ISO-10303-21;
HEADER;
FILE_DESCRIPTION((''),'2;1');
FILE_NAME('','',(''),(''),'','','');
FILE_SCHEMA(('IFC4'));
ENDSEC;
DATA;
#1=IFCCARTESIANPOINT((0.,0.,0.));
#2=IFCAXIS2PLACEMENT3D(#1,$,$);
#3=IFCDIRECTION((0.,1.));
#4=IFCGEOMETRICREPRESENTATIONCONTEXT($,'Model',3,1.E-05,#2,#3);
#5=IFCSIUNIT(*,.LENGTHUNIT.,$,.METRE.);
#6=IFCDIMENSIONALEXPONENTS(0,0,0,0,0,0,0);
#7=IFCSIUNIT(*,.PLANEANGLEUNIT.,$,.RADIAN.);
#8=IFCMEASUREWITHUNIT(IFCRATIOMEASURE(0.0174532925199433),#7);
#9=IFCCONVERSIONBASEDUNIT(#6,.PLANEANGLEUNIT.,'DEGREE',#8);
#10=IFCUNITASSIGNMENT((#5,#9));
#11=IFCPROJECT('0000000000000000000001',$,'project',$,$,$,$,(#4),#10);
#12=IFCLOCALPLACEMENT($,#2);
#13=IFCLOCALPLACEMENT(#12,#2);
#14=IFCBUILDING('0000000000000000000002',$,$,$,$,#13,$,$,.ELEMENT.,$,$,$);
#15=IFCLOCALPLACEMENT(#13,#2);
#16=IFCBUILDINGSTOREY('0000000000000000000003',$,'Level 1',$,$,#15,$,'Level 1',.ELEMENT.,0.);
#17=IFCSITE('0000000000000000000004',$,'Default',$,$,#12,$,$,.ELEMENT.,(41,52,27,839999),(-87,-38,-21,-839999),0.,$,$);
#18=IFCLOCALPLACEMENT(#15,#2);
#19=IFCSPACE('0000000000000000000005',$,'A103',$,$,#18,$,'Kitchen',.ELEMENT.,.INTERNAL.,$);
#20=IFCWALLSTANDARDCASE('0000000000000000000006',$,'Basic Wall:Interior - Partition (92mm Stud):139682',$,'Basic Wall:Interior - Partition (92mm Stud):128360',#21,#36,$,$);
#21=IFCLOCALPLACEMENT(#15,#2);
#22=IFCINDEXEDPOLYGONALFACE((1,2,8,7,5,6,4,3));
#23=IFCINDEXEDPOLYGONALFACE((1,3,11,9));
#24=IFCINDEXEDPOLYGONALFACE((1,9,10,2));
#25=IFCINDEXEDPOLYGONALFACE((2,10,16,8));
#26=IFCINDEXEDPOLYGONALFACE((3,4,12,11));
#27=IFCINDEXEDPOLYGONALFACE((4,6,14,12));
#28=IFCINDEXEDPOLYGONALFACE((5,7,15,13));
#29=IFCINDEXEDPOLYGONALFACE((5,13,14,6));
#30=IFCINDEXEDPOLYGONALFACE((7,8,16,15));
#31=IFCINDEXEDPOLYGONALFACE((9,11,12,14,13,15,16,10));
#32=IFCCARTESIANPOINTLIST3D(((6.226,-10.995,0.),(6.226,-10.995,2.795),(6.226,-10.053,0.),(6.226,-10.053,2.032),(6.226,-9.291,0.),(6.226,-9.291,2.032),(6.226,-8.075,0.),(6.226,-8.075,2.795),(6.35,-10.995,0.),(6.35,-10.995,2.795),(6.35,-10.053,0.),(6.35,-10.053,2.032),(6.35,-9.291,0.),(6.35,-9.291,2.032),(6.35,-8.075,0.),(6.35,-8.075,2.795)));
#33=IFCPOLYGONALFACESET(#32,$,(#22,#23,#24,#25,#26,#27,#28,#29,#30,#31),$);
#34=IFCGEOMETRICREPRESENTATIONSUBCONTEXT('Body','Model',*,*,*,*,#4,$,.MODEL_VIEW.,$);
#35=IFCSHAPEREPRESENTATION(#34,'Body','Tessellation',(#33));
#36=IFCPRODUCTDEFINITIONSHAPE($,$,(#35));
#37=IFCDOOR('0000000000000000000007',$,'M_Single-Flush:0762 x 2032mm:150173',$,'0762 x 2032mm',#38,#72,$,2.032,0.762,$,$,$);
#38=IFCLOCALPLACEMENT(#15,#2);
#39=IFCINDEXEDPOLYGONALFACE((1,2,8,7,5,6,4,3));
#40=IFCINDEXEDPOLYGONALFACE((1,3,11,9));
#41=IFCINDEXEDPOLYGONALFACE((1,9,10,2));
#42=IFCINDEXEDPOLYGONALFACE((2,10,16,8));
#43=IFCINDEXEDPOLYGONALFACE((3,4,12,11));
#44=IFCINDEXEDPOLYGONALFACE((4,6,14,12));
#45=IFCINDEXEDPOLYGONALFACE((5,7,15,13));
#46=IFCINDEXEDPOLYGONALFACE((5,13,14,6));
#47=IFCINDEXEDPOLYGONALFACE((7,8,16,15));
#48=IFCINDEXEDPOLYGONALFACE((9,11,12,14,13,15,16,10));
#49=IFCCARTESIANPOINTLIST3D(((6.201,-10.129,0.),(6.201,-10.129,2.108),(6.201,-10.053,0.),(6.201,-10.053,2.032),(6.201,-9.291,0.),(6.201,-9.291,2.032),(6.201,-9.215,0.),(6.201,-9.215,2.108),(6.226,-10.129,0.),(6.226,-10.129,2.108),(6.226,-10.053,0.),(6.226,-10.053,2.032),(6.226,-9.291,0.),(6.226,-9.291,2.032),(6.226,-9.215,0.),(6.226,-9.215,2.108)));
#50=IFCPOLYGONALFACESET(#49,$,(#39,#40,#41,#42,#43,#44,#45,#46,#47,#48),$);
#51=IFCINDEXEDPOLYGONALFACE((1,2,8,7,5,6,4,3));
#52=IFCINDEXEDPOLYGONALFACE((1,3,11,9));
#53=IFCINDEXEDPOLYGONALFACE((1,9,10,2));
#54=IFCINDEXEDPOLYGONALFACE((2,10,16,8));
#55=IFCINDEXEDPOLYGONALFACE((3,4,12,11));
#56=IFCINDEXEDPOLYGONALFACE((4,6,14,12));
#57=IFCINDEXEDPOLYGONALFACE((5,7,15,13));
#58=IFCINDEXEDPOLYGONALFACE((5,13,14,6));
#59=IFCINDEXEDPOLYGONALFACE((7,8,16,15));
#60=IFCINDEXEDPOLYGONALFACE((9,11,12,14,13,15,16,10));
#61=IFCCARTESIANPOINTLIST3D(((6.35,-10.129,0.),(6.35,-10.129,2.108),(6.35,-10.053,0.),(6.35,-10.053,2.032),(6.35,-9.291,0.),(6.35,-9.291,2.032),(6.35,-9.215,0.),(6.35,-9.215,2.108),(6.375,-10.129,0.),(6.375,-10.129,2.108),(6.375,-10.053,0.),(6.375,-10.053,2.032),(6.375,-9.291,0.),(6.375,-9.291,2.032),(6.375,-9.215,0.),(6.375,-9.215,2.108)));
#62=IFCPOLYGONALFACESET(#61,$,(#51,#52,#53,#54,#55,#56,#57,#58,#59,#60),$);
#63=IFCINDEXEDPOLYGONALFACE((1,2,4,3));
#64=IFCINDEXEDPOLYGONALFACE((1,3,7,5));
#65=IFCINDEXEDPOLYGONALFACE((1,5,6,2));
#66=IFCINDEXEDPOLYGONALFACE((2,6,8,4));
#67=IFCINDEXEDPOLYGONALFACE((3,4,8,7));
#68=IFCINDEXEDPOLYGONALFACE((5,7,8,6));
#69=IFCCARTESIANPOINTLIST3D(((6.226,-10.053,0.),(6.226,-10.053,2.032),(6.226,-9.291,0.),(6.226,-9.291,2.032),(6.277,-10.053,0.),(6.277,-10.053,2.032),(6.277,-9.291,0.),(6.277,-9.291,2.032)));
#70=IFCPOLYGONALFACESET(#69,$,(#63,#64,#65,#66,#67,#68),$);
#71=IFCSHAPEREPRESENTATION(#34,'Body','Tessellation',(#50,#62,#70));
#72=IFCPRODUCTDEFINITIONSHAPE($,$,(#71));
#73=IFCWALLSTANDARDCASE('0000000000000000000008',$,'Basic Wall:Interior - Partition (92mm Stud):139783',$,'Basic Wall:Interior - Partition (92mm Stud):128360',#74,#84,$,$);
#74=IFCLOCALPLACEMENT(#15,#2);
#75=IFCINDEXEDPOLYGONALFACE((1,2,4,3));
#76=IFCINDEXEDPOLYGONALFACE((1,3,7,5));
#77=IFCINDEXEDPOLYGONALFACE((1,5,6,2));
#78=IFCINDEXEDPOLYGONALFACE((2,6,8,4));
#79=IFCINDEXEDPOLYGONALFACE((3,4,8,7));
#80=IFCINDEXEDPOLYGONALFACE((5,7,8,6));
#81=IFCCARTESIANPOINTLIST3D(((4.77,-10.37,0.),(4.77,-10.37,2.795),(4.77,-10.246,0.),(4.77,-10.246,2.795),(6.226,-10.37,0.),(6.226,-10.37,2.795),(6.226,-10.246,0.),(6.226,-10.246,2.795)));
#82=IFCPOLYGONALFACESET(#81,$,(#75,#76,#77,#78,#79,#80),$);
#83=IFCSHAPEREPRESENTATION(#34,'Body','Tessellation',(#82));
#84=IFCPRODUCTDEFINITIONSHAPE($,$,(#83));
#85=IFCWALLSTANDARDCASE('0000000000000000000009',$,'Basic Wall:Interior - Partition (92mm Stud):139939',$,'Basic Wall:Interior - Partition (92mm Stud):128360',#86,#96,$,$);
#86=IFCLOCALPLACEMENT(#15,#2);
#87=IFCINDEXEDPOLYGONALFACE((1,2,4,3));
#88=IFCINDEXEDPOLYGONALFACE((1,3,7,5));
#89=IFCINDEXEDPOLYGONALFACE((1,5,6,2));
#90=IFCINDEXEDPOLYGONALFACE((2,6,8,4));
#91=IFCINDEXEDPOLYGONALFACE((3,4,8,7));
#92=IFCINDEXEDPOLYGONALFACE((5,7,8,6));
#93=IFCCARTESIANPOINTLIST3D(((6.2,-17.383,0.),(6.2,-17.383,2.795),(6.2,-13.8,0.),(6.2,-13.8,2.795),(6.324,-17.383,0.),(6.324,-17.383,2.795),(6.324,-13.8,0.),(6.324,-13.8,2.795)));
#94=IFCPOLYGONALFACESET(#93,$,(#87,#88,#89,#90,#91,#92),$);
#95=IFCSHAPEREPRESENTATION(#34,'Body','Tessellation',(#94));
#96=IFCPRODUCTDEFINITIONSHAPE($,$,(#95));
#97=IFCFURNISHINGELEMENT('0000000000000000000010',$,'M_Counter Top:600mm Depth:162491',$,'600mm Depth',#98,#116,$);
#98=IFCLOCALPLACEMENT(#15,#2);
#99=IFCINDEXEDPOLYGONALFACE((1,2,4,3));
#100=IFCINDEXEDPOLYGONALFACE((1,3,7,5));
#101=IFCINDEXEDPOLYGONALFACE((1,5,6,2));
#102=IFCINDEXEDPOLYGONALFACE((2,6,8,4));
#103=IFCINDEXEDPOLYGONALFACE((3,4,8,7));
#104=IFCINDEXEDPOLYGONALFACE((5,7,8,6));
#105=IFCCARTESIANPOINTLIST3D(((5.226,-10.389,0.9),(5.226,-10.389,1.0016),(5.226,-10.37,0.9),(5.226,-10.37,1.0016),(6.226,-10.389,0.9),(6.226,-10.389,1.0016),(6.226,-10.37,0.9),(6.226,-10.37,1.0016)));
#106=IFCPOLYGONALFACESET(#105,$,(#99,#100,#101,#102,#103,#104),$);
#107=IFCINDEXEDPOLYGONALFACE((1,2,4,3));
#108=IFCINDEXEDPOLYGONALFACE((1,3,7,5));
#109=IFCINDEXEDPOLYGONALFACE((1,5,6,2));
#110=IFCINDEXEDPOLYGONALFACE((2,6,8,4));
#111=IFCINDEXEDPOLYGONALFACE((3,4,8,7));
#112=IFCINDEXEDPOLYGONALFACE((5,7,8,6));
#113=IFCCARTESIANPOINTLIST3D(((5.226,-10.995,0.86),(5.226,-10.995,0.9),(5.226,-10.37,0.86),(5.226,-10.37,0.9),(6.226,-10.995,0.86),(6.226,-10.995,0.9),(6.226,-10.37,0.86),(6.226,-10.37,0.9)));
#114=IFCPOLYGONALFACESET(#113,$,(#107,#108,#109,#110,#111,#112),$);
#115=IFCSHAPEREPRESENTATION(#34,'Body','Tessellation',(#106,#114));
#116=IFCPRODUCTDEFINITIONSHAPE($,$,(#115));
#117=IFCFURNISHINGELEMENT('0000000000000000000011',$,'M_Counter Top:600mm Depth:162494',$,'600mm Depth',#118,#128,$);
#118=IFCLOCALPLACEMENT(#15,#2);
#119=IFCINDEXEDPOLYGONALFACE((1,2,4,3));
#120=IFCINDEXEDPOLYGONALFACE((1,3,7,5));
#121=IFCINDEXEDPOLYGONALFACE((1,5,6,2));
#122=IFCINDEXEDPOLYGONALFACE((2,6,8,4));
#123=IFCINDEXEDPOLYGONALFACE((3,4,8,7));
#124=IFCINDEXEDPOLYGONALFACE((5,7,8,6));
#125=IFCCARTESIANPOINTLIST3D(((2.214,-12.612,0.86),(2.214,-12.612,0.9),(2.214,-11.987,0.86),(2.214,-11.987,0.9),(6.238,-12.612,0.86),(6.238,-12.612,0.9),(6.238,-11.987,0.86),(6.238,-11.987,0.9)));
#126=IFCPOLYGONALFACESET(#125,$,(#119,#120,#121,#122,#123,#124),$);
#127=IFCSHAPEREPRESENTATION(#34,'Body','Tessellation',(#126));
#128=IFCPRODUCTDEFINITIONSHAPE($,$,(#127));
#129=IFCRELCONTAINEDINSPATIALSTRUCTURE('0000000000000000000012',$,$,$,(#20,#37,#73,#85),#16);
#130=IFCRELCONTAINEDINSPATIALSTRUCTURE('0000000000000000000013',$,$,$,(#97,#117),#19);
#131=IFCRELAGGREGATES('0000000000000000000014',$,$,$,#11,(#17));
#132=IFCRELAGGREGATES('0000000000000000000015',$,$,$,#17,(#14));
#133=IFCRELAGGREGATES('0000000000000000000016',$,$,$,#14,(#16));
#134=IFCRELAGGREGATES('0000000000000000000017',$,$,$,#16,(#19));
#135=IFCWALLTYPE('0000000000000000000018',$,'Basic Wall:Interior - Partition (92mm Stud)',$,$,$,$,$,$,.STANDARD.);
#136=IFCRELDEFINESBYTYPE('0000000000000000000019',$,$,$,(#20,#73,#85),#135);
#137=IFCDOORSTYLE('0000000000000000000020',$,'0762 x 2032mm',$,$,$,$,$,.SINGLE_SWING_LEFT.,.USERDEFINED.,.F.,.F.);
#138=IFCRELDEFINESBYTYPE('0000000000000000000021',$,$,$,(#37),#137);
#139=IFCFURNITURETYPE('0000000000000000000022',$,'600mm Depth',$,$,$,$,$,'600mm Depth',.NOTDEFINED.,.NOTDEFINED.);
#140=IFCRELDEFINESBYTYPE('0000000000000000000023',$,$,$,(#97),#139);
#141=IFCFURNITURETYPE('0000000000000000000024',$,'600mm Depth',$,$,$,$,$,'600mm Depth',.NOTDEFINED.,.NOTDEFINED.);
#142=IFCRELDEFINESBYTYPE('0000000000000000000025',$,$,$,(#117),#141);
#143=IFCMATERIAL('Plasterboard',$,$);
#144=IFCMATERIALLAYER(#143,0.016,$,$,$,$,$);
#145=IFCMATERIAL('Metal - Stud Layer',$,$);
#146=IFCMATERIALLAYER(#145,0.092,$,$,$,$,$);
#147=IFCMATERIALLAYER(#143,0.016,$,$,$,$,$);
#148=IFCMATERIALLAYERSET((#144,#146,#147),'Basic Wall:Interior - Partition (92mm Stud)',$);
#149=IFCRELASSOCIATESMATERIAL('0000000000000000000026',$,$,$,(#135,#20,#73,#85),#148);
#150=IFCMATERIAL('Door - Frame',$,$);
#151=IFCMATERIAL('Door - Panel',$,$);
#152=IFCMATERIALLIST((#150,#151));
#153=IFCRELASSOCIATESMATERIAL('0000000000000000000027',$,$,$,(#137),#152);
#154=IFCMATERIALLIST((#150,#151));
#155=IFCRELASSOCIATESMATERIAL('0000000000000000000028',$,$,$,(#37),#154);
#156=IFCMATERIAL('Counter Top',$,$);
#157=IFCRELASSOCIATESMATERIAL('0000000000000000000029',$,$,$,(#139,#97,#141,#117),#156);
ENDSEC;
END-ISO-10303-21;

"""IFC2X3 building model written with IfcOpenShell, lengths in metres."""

from ifc_helpers import new_model, entity, si_unit, converted_unit, direction, frame, frame_2d, origin, place, context, subcontext, project, spatial, polyline, rectangle, outline, extrude, source, transform, mapped, material, material_list, layer, layer_set, layer_usage, type_object, type_shapes, element, fill, save


model = new_model("IFC2X3")

# Units and contexts
model_context = context("Model", 3, precision=1e-05, world=origin(), true_north=direction((0.0, 1.0)))
body_context = subcontext(model_context, "Body", "Model", "MODEL_VIEW")
ifc_project = project(units=[si_unit("LENGTHUNIT", "METRE"), converted_unit("PLANEANGLEUNIT", "DEGREE", entity("IfcRatioMeasure", 0.0174532925199433), si_unit("PLANEANGLEUNIT", "RADIAN"), dimensions=[0, 0, 0, 0, 0, 0, 0])], contexts=[model_context])

# Site, building, storey
site_placement = place(None, origin())
site = spatial("IfcSite", under=ifc_project, at=site_placement, Name="Default", CompositionType="ELEMENT", RefLatitude=(41, 52, 27, 839999), RefLongitude=(-87, -38, -21, -839999), RefElevation=0.0)
building_placement = place(site_placement, origin())
building = spatial("IfcBuilding", under=site, at=building_placement, CompositionType="ELEMENT")
storey_placement = place(building_placement, origin())
storey = spatial("IfcBuildingStorey", under=building, at=storey_placement, Name="Level 1", LongName="Level 1", CompositionType="ELEMENT", Elevation=0.0)

# Shared definitions
ifc_material_1 = material(Name="Metal - Stud Layer")
ifc_material_2 = material(Name="Plasterboard")
ifc_material_3 = material(Name="Door - Frame")
ifc_material_4 = material(Name="Door - Panel")

# Wall, opening, door
ifc_layer_1 = layer(ifc_material_2, 0.016)
ifc_layer_2 = layer(ifc_material_1, 0.092)
ifc_layer_3 = layer(ifc_material_2, 0.016)
ifc_layer_set_1 = layer_set([ifc_layer_1, ifc_layer_2, ifc_layer_3], Name="Basic Wall:Interior - Partition (92mm Stud)")
ifc_layer_usage_1 = layer_usage(ifc_layer_set_1, "AXIS2", "NEGATIVE", 0.062)
wall_type_1 = type_object("IfcWallType", Name="Basic Wall:Interior - Partition (92mm Stud)", PredefinedType="STANDARD", material=ifc_layer_set_1)
wall_1_placement = place(storey_placement, frame((6.288, -10.995, 0.0), z_axis=(0.0, 0.0, 1.0), x_axis=(0.0, 1.0, 0.0)))
wall_1 = element("IfcWallStandardCase", 1, at=wall_1_placement, inside=storey, type_object=wall_type_1, material=ifc_layer_usage_1, Name="Basic Wall:Interior - Partition (92mm Stud):139682", ObjectType="Basic Wall:Interior - Partition (92mm Stud):128360", context=body_context, shape_type="SweptSolid", body=[
    extrude(rectangle(XDim=2.92, YDim=0.124, at=frame_2d((1.46, 0.0), x_axis=(-1.0, 0.0))), origin(), (0.0, 0.0, 1.0), 2.795),
])
opening_1_placement = place(wall_1_placement, frame((0.942, -0.062, 0.0)))
opening_1 = element("IfcOpeningElement", 2, at=opening_1_placement, cuts=wall_1, ObjectType="Opening", context=body_context, shape_type="SweptSolid", body=[
    extrude(rectangle(XDim=0.762, YDim=2.032, at=frame_2d((1.016, 0.381), x_axis=(0.0, -1.0))), frame((0.0, 0.0, 0.0), z_axis=(0.0, 1.0, 0.0), x_axis=(0.0, 0.0, 1.0)), (0.0, 0.0, 1.0), 0.124),
])
ifc_material_list_1 = material_list([ifc_material_3, ifc_material_4])
ifc_material_list_2 = material_list([ifc_material_3, ifc_material_4])
door_style_1 = type_object("IfcDoorStyle", Name="0762 x 2032mm", ConstructionType="USERDEFINED", OperationType="SINGLE_SWING_LEFT", ParameterTakesPrecedence=False, Sizeable=False, material=ifc_material_list_2)
shared_shape_1 = source(origin(), body_context, "Body", "SweptSolid", [
    extrude(outline(polyline([(-0.457, -1.073), (0.457, -1.073), (0.457, 1.035), (0.381, 1.035), (0.381, -0.997), (-0.381, -0.997), (-0.381, 1.035), (-0.457, 1.035), (-0.457, -1.073)])), frame((0.381, 0.149, 1.035), z_axis=(0.0, -1.0, 0.0), x_axis=(-1.0, 0.0, 0.0)), (0.0, 0.0, 1.0), 0.025),
    extrude(outline(polyline([(-1.073, -0.457), (1.035, -0.457), (1.035, -0.381), (-0.997, -0.381), (-0.997, 0.381), (1.035, 0.381), (1.035, 0.457), (-1.073, 0.457), (-1.073, -0.457)])), frame((0.381, 0.0, 1.035), z_axis=(0.0, -1.0, 0.0), x_axis=(0.0, 0.0, -1.0)), (0.0, 0.0, 1.0), 0.025),
    extrude(rectangle(XDim=0.762, YDim=0.051, at=frame_2d((0.0, 0.0), x_axis=(1.0, 0.0))), frame((0.381, 0.0985, 0.0)), (0.0, 0.0, 1.0), 2.032),
])
type_shapes(door_style_1, [shared_shape_1])
door_1_placement = place(opening_1_placement, origin())
door_1 = element("IfcDoor", 3, at=door_1_placement, inside=storey, type_object=door_style_1, material=ifc_material_list_1, Name="M_Single-Flush:0762 x 2032mm:150173", ObjectType="0762 x 2032mm", OverallHeight=2.032, OverallWidth=0.762, context=body_context, shape_type="MappedRepresentation", body=[
    mapped(shared_shape_1, transform((0.0, 0.0, 0.0), scale=1.0)),
])
fill(opening_1, door_1)

# Walls
ifc_layer_usage_2 = layer_usage(ifc_layer_set_1, "AXIS2", "NEGATIVE", 0.062)
wall_2_placement = place(storey_placement, frame((4.77, -10.308, 0.0)))
element("IfcWallStandardCase", 4, at=wall_2_placement, inside=storey, type_object=wall_type_1, material=ifc_layer_usage_2, Name="Basic Wall:Interior - Partition (92mm Stud):139783", ObjectType="Basic Wall:Interior - Partition (92mm Stud):128360", context=body_context, shape_type="SweptSolid", body=[
    extrude(rectangle(XDim=1.456, YDim=0.124, at=frame_2d((0.728, 0.0), x_axis=(-1.0, 0.0))), origin(), (0.0, 0.0, 1.0), 2.795),
])
ifc_layer_usage_3 = layer_usage(ifc_layer_set_1, "AXIS2", "NEGATIVE", 0.062)
wall_3_placement = place(storey_placement, frame((6.262, -13.8, 0.0), z_axis=(0.0, 0.0, 1.0), x_axis=(0.0, -1.0, 0.0)))
element("IfcWallStandardCase", 5, at=wall_3_placement, inside=storey, type_object=wall_type_1, material=ifc_layer_usage_3, Name="Basic Wall:Interior - Partition (92mm Stud):139939", ObjectType="Basic Wall:Interior - Partition (92mm Stud):128360", context=body_context, shape_type="SweptSolid", body=[
    extrude(rectangle(XDim=3.583, YDim=0.124, at=frame_2d((1.7915, 0.0), x_axis=(-1.0, 0.0))), origin(), (0.0, 0.0, 1.0), 2.795),
])

# Shared definitions
space_1_placement = place(storey_placement, origin())
space_1 = spatial("IfcSpace", under=storey, at=space_1_placement, Name="A103", LongName="Kitchen", CompositionType="ELEMENT", InteriorOrExteriorSpace="INTERNAL")

# Furnishing elements
ifc_material_5 = material(Name="Counter Top")
furniture_type_1 = type_object("IfcFurnitureType", Name="600mm Depth", ElementType="600mm Depth", AssemblyPlace="NOTDEFINED", material=ifc_material_5)
shared_shape_2 = source(origin(), body_context, "Body", "SweptSolid", [
    extrude(rectangle(XDim=0.0191, YDim=1.0, at=frame_2d((0.0, 0.0), x_axis=(1.0, 0.0))), frame((-0.7005, -0.0095, 0.9), z_axis=(0.0, 0.0, 1.0), x_axis=(0.0, -1.0, 0.0)), (0.0, 0.0, 1.0), 0.1016),
    extrude(rectangle(XDim=1.0, YDim=0.625, at=frame_2d((0.0, 0.0), x_axis=(1.0, 0.0))), frame((-0.7005, -0.3125, 0.86), z_axis=(0.0, 0.0, 1.0), x_axis=(-1.0, 0.0, 0.0)), (0.0, 0.0, 1.0), 0.04),
])
type_shapes(furniture_type_1, [shared_shape_2])
furnishing_1_placement = place(space_1_placement, frame((6.4265, -10.37, 0.0)))
element("IfcFurnishingElement", 6, at=furnishing_1_placement, inside=space_1, type_object=furniture_type_1, material=ifc_material_5, Name="M_Counter Top:600mm Depth:162491", ObjectType="600mm Depth", context=body_context, shape_type="MappedRepresentation", body=[
    mapped(shared_shape_2, transform((0.0, 0.0, 0.0), scale=1.0)),
])
furniture_type_2 = type_object("IfcFurnitureType", Name="600mm Depth", ElementType="600mm Depth", AssemblyPlace="NOTDEFINED", material=ifc_material_5)
shared_shape_3 = source(origin(), body_context, "Body", "SweptSolid", [
    extrude(rectangle(XDim=4.024, YDim=0.625, at=frame_2d((0.0, 0.0), x_axis=(1.0, 0.0))), frame((0.8115, -0.3125, 0.86), z_axis=(0.0, 0.0, 1.0), x_axis=(-1.0, 0.0, 0.0)), (0.0, 0.0, 1.0), 0.04),
])
type_shapes(furniture_type_2, [shared_shape_3])
furnishing_2_placement = place(space_1_placement, frame((5.0375, -12.612, 0.0), z_axis=(0.0, 0.0, 1.0), x_axis=(-1.0, 0.0, 0.0)))
element("IfcFurnishingElement", 7, at=furnishing_2_placement, inside=space_1, type_object=furniture_type_2, material=ifc_material_5, Name="M_Counter Top:600mm Depth:162494", ObjectType="600mm Depth", context=body_context, shape_type="MappedRepresentation", body=[
    mapped(shared_shape_3, transform((0.0, 0.0, 0.0), scale=1.0)),
])

save(model, "model.ifc")
